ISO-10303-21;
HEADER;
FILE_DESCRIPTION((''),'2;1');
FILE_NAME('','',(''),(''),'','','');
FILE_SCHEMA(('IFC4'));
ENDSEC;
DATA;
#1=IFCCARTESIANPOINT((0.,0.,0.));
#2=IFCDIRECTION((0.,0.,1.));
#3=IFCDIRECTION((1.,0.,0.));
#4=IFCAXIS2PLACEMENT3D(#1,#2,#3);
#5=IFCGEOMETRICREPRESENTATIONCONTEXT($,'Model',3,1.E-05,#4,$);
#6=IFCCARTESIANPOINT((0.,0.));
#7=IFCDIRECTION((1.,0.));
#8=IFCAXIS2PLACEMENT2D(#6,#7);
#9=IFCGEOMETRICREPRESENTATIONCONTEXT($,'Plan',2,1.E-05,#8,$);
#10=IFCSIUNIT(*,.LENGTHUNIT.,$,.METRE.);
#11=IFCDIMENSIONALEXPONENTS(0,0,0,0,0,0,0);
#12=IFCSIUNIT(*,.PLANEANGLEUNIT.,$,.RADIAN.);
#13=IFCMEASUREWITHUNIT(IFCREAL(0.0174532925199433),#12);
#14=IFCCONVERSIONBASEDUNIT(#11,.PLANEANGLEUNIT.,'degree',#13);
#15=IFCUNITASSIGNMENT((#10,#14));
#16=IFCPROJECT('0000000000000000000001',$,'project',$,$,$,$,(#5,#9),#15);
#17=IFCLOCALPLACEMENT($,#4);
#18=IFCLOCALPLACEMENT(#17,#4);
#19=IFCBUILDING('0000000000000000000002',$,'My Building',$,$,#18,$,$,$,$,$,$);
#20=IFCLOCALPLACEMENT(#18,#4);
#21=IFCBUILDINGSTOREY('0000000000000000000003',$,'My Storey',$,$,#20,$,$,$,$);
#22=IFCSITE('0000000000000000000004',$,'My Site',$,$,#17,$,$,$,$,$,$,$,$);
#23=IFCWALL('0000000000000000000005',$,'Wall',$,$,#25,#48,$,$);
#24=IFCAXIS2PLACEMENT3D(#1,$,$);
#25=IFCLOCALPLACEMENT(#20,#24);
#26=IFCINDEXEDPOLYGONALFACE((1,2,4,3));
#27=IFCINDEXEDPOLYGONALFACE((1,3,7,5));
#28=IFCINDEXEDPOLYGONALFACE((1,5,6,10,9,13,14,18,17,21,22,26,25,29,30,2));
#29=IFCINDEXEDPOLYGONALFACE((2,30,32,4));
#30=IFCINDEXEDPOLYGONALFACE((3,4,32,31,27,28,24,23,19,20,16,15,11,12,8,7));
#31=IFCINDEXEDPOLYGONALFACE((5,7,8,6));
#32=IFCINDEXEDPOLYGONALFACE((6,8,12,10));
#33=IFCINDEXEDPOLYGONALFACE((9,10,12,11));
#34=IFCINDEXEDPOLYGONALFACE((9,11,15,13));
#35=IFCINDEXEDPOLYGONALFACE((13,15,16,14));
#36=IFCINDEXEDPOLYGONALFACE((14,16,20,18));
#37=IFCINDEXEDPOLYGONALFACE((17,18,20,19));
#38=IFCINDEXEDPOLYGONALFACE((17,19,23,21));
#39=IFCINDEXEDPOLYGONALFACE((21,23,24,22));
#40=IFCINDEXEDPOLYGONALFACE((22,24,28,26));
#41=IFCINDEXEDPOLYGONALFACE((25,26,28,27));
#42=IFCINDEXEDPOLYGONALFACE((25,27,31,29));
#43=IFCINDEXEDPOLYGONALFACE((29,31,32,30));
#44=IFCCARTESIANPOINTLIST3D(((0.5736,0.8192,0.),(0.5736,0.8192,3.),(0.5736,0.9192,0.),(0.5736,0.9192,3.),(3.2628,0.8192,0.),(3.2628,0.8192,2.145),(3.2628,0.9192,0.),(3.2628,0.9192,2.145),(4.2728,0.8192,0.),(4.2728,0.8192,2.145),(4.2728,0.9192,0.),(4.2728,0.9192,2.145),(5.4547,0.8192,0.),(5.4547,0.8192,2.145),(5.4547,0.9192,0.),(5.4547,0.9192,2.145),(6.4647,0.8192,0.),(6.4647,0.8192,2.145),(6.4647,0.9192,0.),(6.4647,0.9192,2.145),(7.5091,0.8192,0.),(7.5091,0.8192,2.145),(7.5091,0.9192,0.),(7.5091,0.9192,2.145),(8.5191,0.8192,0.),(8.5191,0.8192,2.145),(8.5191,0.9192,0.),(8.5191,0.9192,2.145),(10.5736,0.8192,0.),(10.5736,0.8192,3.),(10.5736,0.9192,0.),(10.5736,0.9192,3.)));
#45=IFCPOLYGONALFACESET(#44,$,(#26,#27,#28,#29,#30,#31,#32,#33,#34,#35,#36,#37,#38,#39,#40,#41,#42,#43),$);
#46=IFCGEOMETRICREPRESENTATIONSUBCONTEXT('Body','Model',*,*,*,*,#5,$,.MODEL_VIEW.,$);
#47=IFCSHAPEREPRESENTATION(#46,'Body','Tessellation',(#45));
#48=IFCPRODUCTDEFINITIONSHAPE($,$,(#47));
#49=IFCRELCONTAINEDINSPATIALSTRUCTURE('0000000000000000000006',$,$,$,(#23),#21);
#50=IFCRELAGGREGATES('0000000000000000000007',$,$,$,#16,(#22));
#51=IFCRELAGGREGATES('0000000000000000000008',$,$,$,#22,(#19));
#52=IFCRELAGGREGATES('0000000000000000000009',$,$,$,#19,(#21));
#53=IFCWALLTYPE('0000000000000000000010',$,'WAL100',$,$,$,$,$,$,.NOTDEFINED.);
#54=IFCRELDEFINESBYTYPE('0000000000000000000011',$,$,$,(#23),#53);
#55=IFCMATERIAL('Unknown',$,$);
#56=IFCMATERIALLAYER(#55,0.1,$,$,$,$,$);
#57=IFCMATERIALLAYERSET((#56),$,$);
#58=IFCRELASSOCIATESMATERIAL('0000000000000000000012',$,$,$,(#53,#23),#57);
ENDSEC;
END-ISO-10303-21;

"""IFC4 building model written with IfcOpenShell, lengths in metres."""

from ifc_helpers import new_model, entity, si_unit, converted_unit, frame, origin_with_axes, origin_2d_with_axis, place, context, subcontext, project, spatial, line, indexed_curve, outline, extrude, source, transform, mapped, material, layer, layer_set, layer_usage, type_object, element, save


model = new_model("IFC4")

# Units and contexts
model_context = context("Model", 3, precision=1e-05, world=origin_with_axes())
plan_context = context("Plan", 2, precision=1e-05, world=origin_2d_with_axis())
body_context = subcontext(model_context, "Body", "Model", "MODEL_VIEW")
ifc_project = project(units=[si_unit("LENGTHUNIT", "METRE"), converted_unit("PLANEANGLEUNIT", "degree", entity("IfcReal", 0.0174532925199433), si_unit("PLANEANGLEUNIT", "RADIAN"), dimensions=[0, 0, 0, 0, 0, 0, 0])], contexts=[model_context, plan_context])

# Site, building, storey
site_placement = place(None, origin_with_axes())
site = spatial("IfcSite", under=ifc_project, at=site_placement, Name="My Site")
building_placement = place(site_placement, origin_with_axes())
building = spatial("IfcBuilding", under=site, at=building_placement, Name="My Building")
storey_placement = place(building_placement, origin_with_axes())
storey = spatial("IfcBuildingStorey", under=building, at=storey_placement, Name="My Storey")

# Wall, openings
ifc_material = material(Name="Unknown")
ifc_layer = layer(ifc_material, 0.1)
ifc_layer_set = layer_set([ifc_layer])
ifc_layer_usage = layer_usage(ifc_layer_set, "AXIS2", "POSITIVE", 0.0)
wall_type = type_object("IfcWallType", Name="WAL100", PredefinedType="NOTDEFINED", material=ifc_layer_set)
wall_placement = place(storey_placement, frame((0.5736, 0.8192, 0.0), z_axis=(0.0, 0.0, 1.0), x_axis=(1.0, 0.0, 0.0)))
wall = element("IfcWall", 1, at=wall_placement, inside=storey, type_object=wall_type, material=ifc_layer_usage, Name="Wall", context=body_context, shape_type="SweptSolid", body=[
    extrude(outline(indexed_curve([(0.0, 0.0), (0.0, 0.1), (10.0, 0.1), (10.0, 0.0)], segments=[line(1, 2, 3, 4, 1)])), origin_with_axes(), (0.0, 0.0, 1.0), 3.0),
])
shared_shape = source(origin_with_axes(), body_context, "Body", "SweptSolid", [
    extrude(outline(indexed_curve([(0.0, 0.0), (1.01, 0.0), (1.01, 2.145), (0.0, 2.145)], segments=[line(1, 2, 3, 4, 1)])), frame((0.0, -0.6, 0.0), z_axis=(0.0, -1.0, 0.0), x_axis=(1.0, 0.0, 0.0)), (0.0, 0.0, -1.0), 1.2),
])
opening_1_placement = place(wall_placement, frame((2.6893, 0.0, 0.0), z_axis=(0.0, 0.0, 1.0), x_axis=(1.0, 0.0, 0.0)))
element("IfcOpeningElement", 2, at=opening_1_placement, cuts=wall, PredefinedType="OPENING", context=body_context, shape_type="MappedRepresentation", body=[
    mapped(shared_shape, transform((0.0, 0.0, 0.0), x_axis=(1.0, 0.0, 0.0), y_axis=(0.0, 1.0, 0.0), z_axis=(0.0, 0.0, 1.0), scale=1.0)),
])
opening_2_placement = place(wall_placement, frame((4.8811, 0.0, 0.0), z_axis=(0.0, 0.0, 1.0), x_axis=(1.0, 0.0, 0.0)))
element("IfcOpeningElement", 3, at=opening_2_placement, cuts=wall, PredefinedType="OPENING", context=body_context, shape_type="MappedRepresentation", body=[
    mapped(shared_shape, transform((0.0, 0.0, 0.0), x_axis=(1.0, 0.0, 0.0), y_axis=(0.0, 1.0, 0.0), z_axis=(0.0, 0.0, 1.0), scale=1.0)),
])
opening_3_placement = place(wall_placement, frame((6.9356, 0.0, 0.0), z_axis=(0.0, 0.0, 1.0), x_axis=(1.0, 0.0, 0.0)))
element("IfcOpeningElement", 4, at=opening_3_placement, cuts=wall, PredefinedType="OPENING", context=body_context, shape_type="MappedRepresentation", body=[
    mapped(shared_shape, transform((0.0, 0.0, 0.0), x_axis=(1.0, 0.0, 0.0), y_axis=(0.0, 1.0, 0.0), z_axis=(0.0, 0.0, 1.0), scale=1.0)),
])

save(model, "model.ifc")
